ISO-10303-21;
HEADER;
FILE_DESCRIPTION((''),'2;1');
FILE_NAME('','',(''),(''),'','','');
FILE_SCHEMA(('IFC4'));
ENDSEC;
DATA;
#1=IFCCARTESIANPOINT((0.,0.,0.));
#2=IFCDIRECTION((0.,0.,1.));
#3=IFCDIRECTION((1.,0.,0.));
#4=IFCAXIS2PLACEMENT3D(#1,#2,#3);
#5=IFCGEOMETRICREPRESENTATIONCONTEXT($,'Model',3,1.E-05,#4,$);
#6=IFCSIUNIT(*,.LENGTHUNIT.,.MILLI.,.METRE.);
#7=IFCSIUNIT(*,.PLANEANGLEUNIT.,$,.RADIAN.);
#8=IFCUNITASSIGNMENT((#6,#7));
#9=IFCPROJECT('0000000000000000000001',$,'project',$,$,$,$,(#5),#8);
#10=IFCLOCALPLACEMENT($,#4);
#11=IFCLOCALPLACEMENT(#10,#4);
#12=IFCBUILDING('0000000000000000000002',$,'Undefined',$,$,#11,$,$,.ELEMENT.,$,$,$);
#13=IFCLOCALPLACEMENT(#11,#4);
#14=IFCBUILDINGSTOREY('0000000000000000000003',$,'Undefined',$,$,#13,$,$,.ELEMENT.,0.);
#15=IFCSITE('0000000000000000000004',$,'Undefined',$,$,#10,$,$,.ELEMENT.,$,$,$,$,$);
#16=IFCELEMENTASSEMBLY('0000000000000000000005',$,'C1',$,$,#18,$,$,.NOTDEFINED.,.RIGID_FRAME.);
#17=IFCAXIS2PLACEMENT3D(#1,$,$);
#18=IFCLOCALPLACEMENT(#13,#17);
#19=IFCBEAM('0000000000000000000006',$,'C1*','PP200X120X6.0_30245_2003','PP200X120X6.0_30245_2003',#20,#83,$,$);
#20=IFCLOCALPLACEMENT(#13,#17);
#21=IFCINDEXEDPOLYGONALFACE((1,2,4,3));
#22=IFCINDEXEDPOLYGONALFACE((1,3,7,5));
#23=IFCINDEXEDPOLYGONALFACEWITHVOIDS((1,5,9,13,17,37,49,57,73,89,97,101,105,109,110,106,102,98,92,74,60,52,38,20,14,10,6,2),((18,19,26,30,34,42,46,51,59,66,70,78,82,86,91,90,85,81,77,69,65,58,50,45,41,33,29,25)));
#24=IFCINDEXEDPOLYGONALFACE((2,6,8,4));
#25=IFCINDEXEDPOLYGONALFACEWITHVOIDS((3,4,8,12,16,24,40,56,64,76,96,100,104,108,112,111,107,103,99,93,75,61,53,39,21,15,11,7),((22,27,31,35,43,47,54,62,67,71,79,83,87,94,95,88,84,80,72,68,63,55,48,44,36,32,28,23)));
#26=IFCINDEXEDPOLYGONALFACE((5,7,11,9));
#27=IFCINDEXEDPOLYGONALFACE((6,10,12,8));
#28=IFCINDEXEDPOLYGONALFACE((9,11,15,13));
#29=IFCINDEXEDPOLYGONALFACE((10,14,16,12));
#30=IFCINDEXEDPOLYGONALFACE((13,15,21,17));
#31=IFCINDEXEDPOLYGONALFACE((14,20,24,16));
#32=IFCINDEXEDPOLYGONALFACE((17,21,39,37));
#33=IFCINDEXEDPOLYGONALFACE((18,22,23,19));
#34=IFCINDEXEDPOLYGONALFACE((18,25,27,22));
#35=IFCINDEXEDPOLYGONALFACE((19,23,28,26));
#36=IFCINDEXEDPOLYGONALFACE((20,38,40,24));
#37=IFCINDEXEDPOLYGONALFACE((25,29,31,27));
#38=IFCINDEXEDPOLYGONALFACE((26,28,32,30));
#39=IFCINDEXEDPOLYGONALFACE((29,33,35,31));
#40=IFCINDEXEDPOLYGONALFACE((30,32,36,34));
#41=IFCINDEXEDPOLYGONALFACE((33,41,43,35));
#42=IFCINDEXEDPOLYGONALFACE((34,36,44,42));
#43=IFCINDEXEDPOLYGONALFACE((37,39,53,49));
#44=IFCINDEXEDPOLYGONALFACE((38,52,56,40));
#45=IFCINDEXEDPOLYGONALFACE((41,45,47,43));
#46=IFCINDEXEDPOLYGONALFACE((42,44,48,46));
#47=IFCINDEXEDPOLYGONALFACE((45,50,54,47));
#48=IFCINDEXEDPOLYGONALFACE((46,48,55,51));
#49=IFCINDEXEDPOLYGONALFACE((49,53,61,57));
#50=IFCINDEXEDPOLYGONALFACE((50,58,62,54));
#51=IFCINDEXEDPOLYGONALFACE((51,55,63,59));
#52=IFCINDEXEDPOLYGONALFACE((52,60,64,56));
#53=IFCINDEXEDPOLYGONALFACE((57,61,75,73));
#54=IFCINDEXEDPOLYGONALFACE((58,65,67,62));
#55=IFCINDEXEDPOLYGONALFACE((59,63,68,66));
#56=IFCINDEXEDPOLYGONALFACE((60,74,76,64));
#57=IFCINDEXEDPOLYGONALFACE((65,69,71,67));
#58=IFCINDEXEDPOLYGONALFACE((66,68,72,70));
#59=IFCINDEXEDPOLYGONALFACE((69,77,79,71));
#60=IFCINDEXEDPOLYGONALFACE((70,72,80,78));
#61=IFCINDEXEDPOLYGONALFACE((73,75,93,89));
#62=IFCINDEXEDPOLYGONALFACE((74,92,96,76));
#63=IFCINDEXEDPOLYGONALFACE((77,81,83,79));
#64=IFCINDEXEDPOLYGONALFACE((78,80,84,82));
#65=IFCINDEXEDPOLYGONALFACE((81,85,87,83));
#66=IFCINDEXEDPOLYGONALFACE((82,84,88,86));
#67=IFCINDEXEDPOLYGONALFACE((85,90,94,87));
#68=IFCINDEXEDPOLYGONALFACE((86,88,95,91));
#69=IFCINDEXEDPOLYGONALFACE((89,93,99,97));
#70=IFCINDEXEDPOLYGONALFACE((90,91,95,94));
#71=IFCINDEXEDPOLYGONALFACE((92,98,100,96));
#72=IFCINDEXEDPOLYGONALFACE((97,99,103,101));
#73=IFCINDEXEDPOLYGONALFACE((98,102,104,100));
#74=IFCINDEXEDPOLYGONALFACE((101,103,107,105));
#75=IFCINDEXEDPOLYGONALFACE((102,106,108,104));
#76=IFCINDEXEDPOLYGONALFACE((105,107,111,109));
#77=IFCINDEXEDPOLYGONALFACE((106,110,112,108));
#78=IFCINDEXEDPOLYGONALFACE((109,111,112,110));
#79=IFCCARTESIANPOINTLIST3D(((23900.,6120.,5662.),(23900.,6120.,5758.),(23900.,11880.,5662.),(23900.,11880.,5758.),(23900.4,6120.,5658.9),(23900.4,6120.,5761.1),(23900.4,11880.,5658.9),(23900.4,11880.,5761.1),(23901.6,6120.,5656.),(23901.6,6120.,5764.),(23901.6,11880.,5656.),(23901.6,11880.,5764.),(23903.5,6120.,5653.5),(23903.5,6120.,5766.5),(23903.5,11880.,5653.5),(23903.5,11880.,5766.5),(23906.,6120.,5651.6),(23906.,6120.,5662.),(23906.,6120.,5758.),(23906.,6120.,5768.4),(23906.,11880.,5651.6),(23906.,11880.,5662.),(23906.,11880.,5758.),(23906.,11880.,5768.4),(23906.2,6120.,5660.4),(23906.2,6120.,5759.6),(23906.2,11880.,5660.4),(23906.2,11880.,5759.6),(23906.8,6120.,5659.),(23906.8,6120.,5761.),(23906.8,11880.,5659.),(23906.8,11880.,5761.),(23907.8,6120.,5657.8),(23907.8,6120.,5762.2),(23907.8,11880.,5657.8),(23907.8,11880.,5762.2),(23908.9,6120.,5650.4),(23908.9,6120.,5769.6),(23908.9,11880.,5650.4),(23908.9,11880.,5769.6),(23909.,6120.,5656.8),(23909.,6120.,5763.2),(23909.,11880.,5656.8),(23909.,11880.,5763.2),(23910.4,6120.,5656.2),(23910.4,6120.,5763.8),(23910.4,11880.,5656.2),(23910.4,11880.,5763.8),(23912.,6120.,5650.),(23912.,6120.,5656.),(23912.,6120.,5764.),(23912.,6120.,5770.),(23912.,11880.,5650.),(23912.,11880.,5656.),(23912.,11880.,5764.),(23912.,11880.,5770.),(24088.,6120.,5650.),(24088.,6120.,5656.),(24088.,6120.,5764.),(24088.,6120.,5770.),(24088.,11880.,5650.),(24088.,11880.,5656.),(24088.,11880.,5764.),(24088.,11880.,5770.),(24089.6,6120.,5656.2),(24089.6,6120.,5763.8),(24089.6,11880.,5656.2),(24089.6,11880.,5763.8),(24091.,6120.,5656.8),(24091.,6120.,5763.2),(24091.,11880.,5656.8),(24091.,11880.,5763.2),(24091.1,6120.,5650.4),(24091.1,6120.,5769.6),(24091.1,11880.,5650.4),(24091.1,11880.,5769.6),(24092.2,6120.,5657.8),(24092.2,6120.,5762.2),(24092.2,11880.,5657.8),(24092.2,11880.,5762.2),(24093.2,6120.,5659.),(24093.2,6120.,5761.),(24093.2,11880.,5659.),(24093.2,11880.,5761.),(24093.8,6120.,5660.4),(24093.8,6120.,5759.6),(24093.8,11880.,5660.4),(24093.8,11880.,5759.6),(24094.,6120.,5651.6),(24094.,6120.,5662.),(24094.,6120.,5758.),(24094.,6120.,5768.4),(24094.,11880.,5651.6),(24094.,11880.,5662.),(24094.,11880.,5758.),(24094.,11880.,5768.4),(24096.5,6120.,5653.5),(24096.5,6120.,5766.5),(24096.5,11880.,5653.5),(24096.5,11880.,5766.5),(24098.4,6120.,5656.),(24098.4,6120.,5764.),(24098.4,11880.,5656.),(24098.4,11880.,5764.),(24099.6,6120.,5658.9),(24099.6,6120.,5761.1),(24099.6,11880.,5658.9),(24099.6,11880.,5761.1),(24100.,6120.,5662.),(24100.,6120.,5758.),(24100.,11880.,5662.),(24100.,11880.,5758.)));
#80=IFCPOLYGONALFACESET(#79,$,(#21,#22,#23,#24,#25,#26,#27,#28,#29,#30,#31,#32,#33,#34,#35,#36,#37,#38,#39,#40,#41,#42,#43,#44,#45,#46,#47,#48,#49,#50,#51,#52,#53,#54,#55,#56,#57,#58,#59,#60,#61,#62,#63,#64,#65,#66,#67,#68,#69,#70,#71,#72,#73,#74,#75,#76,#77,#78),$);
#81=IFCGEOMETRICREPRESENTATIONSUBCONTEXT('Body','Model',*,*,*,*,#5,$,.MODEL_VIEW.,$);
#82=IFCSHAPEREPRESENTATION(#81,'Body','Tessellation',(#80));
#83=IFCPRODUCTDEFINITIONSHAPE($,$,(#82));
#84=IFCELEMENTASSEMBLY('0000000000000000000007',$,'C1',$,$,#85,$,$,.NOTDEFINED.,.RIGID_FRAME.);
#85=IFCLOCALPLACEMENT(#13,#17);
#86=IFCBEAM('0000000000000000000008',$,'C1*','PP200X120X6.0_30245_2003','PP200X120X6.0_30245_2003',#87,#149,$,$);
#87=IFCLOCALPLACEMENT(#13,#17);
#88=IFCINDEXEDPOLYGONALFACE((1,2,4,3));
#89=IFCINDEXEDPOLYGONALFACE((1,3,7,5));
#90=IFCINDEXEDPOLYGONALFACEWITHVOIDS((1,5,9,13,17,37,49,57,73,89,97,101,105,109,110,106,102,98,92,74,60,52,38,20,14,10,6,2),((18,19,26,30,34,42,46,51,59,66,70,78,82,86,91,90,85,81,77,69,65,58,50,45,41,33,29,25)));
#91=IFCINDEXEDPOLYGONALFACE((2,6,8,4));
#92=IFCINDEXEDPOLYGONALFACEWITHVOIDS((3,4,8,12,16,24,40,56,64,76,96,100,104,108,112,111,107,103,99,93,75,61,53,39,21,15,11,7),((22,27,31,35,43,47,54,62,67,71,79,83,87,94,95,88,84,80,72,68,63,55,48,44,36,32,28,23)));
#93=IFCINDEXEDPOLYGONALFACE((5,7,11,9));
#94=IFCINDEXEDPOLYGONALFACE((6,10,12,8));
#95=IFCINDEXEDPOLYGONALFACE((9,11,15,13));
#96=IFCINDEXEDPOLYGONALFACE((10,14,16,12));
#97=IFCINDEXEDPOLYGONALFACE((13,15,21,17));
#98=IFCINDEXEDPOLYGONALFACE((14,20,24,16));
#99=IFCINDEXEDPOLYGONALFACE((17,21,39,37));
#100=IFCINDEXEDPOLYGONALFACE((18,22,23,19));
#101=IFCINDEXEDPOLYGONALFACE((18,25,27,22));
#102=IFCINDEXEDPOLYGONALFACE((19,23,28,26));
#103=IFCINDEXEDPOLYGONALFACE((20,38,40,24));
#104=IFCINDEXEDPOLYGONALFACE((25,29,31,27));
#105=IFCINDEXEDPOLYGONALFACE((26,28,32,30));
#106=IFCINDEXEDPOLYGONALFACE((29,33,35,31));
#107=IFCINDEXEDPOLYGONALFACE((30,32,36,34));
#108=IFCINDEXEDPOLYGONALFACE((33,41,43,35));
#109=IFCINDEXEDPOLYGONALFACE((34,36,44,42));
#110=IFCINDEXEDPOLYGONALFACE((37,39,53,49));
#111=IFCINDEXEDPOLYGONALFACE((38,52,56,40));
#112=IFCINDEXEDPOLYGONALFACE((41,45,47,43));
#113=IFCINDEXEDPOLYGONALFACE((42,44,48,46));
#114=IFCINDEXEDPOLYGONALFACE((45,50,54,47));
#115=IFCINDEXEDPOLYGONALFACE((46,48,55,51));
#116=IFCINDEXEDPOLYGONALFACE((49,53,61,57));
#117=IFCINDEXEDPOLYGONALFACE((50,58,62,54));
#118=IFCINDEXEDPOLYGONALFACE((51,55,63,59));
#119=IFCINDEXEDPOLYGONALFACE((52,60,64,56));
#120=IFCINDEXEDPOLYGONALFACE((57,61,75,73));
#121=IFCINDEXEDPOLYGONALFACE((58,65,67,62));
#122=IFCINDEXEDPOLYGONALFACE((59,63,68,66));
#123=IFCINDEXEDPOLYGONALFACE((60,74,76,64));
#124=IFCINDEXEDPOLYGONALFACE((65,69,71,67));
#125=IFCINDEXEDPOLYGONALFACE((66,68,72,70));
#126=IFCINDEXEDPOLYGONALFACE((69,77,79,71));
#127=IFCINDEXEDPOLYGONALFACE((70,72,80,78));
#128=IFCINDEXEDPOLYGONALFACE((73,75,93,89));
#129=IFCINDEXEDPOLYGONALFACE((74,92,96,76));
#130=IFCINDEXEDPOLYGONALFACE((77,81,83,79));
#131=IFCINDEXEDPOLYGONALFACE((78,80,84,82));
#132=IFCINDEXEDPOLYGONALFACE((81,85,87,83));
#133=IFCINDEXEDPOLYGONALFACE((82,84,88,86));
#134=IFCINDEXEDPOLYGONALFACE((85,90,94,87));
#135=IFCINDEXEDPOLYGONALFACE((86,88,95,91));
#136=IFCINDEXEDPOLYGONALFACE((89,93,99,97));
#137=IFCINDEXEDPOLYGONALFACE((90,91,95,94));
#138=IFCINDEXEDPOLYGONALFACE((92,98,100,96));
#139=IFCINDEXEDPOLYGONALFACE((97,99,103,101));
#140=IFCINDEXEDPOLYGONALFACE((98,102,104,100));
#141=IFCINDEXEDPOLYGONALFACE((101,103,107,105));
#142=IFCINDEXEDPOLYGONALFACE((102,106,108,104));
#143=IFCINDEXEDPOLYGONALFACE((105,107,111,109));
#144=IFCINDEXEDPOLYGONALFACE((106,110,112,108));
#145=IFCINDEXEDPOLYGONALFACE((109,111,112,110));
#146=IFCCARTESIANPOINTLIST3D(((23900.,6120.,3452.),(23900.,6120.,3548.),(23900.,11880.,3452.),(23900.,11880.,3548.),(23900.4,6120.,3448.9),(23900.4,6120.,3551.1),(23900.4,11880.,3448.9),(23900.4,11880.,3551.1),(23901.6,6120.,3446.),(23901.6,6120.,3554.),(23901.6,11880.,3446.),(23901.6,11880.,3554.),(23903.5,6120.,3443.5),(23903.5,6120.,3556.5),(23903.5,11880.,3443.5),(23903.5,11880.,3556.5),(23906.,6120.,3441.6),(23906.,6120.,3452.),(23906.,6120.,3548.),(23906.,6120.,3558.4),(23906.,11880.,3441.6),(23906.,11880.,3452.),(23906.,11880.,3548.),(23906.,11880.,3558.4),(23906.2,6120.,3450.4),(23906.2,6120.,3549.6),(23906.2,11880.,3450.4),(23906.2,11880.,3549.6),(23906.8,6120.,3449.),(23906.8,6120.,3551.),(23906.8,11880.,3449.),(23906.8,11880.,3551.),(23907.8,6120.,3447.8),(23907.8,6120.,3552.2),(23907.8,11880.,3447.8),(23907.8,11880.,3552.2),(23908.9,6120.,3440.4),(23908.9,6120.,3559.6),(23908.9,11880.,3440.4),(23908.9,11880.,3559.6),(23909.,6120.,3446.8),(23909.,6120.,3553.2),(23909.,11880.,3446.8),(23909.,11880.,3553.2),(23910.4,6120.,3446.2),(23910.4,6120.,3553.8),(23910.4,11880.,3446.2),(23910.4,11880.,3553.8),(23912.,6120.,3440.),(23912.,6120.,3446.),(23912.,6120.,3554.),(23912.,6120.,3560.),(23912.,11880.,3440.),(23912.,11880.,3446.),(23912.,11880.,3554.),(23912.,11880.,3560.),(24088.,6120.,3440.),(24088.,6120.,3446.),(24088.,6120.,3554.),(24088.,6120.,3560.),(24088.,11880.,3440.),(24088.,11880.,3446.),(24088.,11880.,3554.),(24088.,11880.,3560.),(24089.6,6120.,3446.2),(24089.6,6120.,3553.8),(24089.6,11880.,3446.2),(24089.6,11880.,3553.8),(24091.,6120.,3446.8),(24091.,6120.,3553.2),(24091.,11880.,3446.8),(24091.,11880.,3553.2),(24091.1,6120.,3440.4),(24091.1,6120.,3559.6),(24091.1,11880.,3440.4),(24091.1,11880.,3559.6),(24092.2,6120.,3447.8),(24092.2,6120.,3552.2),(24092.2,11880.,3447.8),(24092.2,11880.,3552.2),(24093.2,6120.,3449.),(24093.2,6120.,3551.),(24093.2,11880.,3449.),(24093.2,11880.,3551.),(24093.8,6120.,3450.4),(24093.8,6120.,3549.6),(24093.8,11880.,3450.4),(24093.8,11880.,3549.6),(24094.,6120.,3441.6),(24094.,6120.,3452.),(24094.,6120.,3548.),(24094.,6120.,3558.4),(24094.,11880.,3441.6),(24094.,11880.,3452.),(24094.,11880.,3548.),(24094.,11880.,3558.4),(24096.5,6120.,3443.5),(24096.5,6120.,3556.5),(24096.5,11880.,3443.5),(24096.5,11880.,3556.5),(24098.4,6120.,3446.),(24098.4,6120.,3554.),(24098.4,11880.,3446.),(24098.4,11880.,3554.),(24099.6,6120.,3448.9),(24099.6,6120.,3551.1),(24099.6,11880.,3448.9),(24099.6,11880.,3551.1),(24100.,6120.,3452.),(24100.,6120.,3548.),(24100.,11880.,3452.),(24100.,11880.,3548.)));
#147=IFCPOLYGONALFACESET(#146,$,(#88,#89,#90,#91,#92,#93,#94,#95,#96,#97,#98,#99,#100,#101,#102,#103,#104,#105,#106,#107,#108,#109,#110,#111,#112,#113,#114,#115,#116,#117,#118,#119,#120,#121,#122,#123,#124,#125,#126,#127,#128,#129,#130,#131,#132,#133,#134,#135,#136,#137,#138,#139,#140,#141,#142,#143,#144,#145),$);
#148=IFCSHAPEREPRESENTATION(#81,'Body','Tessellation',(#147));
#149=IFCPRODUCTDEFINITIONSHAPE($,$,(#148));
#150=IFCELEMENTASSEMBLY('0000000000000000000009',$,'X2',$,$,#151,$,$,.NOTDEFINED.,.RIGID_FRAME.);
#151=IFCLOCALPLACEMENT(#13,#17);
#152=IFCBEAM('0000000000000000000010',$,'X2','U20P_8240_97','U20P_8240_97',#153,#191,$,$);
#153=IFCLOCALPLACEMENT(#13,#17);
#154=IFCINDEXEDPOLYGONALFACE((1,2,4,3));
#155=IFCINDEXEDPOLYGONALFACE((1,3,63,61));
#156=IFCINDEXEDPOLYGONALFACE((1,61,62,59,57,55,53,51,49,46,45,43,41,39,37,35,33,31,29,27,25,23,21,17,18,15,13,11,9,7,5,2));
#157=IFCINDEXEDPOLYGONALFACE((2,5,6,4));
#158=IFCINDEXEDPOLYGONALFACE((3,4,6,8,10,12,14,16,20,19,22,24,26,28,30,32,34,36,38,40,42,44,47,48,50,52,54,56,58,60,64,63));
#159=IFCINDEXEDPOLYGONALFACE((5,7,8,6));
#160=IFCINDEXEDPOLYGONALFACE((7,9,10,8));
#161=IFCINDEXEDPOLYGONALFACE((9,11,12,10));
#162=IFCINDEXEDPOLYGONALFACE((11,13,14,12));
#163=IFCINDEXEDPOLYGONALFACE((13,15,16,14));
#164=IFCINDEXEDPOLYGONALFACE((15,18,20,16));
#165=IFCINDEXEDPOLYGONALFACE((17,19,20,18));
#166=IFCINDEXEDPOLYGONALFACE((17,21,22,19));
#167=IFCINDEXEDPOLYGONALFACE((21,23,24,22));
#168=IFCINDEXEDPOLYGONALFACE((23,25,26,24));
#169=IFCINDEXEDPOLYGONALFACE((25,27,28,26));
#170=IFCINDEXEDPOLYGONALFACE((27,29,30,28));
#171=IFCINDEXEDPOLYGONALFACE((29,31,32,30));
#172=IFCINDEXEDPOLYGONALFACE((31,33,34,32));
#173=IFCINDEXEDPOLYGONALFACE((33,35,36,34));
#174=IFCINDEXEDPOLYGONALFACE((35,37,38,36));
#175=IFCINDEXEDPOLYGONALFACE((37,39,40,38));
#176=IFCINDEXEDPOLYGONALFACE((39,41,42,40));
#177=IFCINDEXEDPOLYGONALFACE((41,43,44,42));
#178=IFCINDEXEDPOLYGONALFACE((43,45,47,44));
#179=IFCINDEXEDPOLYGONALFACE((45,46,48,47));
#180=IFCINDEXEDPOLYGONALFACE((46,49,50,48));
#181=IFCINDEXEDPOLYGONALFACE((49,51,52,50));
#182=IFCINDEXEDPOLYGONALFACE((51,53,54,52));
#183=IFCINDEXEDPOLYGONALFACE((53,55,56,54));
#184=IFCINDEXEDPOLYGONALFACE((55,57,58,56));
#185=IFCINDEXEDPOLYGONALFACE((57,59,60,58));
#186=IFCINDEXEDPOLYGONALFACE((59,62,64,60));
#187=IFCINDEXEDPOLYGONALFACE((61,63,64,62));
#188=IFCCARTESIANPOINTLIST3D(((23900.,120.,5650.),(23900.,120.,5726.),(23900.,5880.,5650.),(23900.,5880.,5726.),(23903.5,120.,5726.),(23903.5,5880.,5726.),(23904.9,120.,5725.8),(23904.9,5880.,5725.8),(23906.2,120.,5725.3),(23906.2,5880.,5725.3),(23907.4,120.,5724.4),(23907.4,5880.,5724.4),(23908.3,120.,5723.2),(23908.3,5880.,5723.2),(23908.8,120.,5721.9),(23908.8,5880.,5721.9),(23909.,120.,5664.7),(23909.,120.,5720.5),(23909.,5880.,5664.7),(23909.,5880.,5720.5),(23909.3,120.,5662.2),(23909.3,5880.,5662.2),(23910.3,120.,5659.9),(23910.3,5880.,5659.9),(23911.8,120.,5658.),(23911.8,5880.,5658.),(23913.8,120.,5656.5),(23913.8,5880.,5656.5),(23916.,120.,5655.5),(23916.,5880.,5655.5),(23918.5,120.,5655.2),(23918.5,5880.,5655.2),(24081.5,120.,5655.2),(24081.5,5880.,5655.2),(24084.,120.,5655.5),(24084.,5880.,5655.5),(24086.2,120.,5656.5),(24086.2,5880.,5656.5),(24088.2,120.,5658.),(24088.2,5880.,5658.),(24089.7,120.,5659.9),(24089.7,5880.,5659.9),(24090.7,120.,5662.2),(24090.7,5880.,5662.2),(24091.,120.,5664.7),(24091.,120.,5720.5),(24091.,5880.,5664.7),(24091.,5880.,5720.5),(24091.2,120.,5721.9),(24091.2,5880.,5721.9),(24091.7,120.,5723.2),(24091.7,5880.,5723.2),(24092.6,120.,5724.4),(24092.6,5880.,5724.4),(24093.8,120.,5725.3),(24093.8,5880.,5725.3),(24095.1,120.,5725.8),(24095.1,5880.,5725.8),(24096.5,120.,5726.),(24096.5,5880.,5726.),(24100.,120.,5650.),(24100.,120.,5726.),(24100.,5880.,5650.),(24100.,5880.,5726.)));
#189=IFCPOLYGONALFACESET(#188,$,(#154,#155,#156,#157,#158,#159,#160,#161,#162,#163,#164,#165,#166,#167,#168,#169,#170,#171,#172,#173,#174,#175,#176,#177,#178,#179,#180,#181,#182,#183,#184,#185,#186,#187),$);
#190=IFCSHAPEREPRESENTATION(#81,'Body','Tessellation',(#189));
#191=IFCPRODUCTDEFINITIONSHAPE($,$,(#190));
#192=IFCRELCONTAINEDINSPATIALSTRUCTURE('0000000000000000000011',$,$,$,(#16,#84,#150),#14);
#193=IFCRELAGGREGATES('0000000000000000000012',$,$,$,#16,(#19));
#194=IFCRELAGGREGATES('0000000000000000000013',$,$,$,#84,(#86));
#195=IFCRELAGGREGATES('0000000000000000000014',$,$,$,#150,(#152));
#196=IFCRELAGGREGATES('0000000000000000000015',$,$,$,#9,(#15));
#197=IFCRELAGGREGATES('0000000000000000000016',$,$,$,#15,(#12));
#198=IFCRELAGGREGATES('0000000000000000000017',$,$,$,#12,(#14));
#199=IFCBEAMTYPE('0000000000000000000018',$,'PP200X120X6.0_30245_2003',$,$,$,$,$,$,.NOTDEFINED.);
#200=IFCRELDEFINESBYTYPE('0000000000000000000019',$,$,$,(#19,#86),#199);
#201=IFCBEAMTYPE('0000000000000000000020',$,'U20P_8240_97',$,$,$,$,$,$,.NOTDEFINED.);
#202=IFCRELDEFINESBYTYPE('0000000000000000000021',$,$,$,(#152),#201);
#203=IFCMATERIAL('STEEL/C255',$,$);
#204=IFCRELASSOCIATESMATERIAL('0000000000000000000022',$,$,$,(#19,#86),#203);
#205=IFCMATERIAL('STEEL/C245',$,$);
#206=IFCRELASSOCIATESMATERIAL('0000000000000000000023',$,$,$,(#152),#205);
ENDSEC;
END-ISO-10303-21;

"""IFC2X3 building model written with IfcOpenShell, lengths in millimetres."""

from ifc_helpers import new_model, si_unit, frame, origin_with_axes, origin_2d_with_axis, place, context, subcontext, project, spatial, hollow_rectangle, u_section, extrude, material, type_object, element, aggregate, save


model = new_model("IFC2X3")

# Units and contexts
model_context = context("Model", 3, precision=1e-05, world=origin_with_axes())
body_context = subcontext(model_context, "Body", "Model", "MODEL_VIEW")
ifc_project = project(units=[si_unit("LENGTHUNIT", "METRE", prefix="MILLI"), si_unit("PLANEANGLEUNIT", "RADIAN")], contexts=[model_context])

# Site, building, storey
site_placement = place(None, origin_with_axes())
site = spatial("IfcSite", under=ifc_project, at=site_placement, Name="Undefined", CompositionType="ELEMENT")
building_placement = place(site_placement, origin_with_axes())
building = spatial("IfcBuilding", under=site, at=building_placement, Name="Undefined", CompositionType="ELEMENT")
storey_placement = place(building_placement, origin_with_axes())
storey = spatial("IfcBuildingStorey", under=building, at=storey_placement, Name="Undefined", CompositionType="ELEMENT", Elevation=0.0)

# Shared definitions
ifc_material_1 = material(Name="STEEL/C245")

# Element assemblies, beams
ifc_material_2 = material(Name="STEEL/C255")
assembly_1_placement = place(storey_placement, origin_with_axes())
assembly_1 = element("IfcElementAssembly", 1, at=assembly_1_placement, inside=storey, Name="C1", AssemblyPlace="NOTDEFINED", PredefinedType="RIGID_FRAME")
beam_type_1 = type_object("IfcBeamType", Name="PP200X120X6.0_30245_2003", PredefinedType="NOTDEFINED")
beam_1_placement = place(assembly_1_placement, frame((24000.0, 6120.0, 5710.0), z_axis=(-1.0, 0.0, 0.0), x_axis=(0.0, 1.0, 0.0)))
beam_1 = element("IfcBeam", 2, at=beam_1_placement, type_object=beam_type_1, material=ifc_material_2, Name="C1*", Description="PP200X120X6.0_30245_2003", ObjectType="PP200X120X6.0_30245_2003", context=body_context, shape_type="SweptSolid", body=[
    extrude(hollow_rectangle(XDim=120.0, YDim=200.0, WallThickness=6.0, InnerFilletRadius=6.0, OuterFilletRadius=12.0, at=origin_2d_with_axis()), frame((5760.0, 0.0, 0.0), z_axis=(-1.0, 0.0, 0.0), x_axis=(0.0, -1.0, 0.0)), (0.0, 0.0, 1.0), 5760.0),
])
aggregate(assembly_1, [beam_1])
assembly_2_placement = place(storey_placement, origin_with_axes())
assembly_2 = element("IfcElementAssembly", 3, at=assembly_2_placement, inside=storey, Name="C1", AssemblyPlace="NOTDEFINED", PredefinedType="RIGID_FRAME")
beam_2_placement = place(assembly_2_placement, frame((24000.0, 6120.0, 3500.0), z_axis=(-1.0, 0.0, 0.0), x_axis=(0.0, 1.0, 0.0)))
beam_2 = element("IfcBeam", 4, at=beam_2_placement, type_object=beam_type_1, material=ifc_material_2, Name="C1*", Description="PP200X120X6.0_30245_2003", ObjectType="PP200X120X6.0_30245_2003", context=body_context, shape_type="SweptSolid", body=[
    extrude(hollow_rectangle(XDim=120.0, YDim=200.0, WallThickness=6.0, InnerFilletRadius=6.0, OuterFilletRadius=12.0, at=origin_2d_with_axis()), frame((5760.0, 0.0, 0.0), z_axis=(-1.0, 0.0, 0.0), x_axis=(0.0, -1.0, 0.0)), (0.0, 0.0, 1.0), 5760.0),
])
aggregate(assembly_2, [beam_2])
assembly_3_placement = place(storey_placement, origin_with_axes())
assembly_3 = element("IfcElementAssembly", 5, at=assembly_3_placement, inside=storey, Name="X2", AssemblyPlace="NOTDEFINED", PredefinedType="RIGID_FRAME")
beam_type_2 = type_object("IfcBeamType", Name="U20P_8240_97", PredefinedType="NOTDEFINED")
beam_3_placement = place(assembly_3_placement, frame((24000.0, 120.0, 5688.0), z_axis=(-1.0, 0.0, 0.0), x_axis=(0.0, 1.0, 0.0)))
beam_3 = element("IfcBeam", 6, at=beam_3_placement, type_object=beam_type_2, material=ifc_material_1, Name="X2", Description="U20P_8240_97", ObjectType="U20P_8240_97", context=body_context, shape_type="SweptSolid", body=[
    extrude(u_section(Depth=200.0, FlangeWidth=76.0, WebThickness=5.2, FlangeThickness=9.0, FilletRadius=9.5, EdgeRadius=5.5, at=origin_2d_with_axis()), frame((5760.0, 0.0, 0.0), z_axis=(-1.0, 0.0, 0.0), x_axis=(0.0, -1.0, 0.0)), (0.0, 0.0, 1.0), 5760.0),
])
aggregate(assembly_3, [beam_3])

save(model, "model.ifc")
